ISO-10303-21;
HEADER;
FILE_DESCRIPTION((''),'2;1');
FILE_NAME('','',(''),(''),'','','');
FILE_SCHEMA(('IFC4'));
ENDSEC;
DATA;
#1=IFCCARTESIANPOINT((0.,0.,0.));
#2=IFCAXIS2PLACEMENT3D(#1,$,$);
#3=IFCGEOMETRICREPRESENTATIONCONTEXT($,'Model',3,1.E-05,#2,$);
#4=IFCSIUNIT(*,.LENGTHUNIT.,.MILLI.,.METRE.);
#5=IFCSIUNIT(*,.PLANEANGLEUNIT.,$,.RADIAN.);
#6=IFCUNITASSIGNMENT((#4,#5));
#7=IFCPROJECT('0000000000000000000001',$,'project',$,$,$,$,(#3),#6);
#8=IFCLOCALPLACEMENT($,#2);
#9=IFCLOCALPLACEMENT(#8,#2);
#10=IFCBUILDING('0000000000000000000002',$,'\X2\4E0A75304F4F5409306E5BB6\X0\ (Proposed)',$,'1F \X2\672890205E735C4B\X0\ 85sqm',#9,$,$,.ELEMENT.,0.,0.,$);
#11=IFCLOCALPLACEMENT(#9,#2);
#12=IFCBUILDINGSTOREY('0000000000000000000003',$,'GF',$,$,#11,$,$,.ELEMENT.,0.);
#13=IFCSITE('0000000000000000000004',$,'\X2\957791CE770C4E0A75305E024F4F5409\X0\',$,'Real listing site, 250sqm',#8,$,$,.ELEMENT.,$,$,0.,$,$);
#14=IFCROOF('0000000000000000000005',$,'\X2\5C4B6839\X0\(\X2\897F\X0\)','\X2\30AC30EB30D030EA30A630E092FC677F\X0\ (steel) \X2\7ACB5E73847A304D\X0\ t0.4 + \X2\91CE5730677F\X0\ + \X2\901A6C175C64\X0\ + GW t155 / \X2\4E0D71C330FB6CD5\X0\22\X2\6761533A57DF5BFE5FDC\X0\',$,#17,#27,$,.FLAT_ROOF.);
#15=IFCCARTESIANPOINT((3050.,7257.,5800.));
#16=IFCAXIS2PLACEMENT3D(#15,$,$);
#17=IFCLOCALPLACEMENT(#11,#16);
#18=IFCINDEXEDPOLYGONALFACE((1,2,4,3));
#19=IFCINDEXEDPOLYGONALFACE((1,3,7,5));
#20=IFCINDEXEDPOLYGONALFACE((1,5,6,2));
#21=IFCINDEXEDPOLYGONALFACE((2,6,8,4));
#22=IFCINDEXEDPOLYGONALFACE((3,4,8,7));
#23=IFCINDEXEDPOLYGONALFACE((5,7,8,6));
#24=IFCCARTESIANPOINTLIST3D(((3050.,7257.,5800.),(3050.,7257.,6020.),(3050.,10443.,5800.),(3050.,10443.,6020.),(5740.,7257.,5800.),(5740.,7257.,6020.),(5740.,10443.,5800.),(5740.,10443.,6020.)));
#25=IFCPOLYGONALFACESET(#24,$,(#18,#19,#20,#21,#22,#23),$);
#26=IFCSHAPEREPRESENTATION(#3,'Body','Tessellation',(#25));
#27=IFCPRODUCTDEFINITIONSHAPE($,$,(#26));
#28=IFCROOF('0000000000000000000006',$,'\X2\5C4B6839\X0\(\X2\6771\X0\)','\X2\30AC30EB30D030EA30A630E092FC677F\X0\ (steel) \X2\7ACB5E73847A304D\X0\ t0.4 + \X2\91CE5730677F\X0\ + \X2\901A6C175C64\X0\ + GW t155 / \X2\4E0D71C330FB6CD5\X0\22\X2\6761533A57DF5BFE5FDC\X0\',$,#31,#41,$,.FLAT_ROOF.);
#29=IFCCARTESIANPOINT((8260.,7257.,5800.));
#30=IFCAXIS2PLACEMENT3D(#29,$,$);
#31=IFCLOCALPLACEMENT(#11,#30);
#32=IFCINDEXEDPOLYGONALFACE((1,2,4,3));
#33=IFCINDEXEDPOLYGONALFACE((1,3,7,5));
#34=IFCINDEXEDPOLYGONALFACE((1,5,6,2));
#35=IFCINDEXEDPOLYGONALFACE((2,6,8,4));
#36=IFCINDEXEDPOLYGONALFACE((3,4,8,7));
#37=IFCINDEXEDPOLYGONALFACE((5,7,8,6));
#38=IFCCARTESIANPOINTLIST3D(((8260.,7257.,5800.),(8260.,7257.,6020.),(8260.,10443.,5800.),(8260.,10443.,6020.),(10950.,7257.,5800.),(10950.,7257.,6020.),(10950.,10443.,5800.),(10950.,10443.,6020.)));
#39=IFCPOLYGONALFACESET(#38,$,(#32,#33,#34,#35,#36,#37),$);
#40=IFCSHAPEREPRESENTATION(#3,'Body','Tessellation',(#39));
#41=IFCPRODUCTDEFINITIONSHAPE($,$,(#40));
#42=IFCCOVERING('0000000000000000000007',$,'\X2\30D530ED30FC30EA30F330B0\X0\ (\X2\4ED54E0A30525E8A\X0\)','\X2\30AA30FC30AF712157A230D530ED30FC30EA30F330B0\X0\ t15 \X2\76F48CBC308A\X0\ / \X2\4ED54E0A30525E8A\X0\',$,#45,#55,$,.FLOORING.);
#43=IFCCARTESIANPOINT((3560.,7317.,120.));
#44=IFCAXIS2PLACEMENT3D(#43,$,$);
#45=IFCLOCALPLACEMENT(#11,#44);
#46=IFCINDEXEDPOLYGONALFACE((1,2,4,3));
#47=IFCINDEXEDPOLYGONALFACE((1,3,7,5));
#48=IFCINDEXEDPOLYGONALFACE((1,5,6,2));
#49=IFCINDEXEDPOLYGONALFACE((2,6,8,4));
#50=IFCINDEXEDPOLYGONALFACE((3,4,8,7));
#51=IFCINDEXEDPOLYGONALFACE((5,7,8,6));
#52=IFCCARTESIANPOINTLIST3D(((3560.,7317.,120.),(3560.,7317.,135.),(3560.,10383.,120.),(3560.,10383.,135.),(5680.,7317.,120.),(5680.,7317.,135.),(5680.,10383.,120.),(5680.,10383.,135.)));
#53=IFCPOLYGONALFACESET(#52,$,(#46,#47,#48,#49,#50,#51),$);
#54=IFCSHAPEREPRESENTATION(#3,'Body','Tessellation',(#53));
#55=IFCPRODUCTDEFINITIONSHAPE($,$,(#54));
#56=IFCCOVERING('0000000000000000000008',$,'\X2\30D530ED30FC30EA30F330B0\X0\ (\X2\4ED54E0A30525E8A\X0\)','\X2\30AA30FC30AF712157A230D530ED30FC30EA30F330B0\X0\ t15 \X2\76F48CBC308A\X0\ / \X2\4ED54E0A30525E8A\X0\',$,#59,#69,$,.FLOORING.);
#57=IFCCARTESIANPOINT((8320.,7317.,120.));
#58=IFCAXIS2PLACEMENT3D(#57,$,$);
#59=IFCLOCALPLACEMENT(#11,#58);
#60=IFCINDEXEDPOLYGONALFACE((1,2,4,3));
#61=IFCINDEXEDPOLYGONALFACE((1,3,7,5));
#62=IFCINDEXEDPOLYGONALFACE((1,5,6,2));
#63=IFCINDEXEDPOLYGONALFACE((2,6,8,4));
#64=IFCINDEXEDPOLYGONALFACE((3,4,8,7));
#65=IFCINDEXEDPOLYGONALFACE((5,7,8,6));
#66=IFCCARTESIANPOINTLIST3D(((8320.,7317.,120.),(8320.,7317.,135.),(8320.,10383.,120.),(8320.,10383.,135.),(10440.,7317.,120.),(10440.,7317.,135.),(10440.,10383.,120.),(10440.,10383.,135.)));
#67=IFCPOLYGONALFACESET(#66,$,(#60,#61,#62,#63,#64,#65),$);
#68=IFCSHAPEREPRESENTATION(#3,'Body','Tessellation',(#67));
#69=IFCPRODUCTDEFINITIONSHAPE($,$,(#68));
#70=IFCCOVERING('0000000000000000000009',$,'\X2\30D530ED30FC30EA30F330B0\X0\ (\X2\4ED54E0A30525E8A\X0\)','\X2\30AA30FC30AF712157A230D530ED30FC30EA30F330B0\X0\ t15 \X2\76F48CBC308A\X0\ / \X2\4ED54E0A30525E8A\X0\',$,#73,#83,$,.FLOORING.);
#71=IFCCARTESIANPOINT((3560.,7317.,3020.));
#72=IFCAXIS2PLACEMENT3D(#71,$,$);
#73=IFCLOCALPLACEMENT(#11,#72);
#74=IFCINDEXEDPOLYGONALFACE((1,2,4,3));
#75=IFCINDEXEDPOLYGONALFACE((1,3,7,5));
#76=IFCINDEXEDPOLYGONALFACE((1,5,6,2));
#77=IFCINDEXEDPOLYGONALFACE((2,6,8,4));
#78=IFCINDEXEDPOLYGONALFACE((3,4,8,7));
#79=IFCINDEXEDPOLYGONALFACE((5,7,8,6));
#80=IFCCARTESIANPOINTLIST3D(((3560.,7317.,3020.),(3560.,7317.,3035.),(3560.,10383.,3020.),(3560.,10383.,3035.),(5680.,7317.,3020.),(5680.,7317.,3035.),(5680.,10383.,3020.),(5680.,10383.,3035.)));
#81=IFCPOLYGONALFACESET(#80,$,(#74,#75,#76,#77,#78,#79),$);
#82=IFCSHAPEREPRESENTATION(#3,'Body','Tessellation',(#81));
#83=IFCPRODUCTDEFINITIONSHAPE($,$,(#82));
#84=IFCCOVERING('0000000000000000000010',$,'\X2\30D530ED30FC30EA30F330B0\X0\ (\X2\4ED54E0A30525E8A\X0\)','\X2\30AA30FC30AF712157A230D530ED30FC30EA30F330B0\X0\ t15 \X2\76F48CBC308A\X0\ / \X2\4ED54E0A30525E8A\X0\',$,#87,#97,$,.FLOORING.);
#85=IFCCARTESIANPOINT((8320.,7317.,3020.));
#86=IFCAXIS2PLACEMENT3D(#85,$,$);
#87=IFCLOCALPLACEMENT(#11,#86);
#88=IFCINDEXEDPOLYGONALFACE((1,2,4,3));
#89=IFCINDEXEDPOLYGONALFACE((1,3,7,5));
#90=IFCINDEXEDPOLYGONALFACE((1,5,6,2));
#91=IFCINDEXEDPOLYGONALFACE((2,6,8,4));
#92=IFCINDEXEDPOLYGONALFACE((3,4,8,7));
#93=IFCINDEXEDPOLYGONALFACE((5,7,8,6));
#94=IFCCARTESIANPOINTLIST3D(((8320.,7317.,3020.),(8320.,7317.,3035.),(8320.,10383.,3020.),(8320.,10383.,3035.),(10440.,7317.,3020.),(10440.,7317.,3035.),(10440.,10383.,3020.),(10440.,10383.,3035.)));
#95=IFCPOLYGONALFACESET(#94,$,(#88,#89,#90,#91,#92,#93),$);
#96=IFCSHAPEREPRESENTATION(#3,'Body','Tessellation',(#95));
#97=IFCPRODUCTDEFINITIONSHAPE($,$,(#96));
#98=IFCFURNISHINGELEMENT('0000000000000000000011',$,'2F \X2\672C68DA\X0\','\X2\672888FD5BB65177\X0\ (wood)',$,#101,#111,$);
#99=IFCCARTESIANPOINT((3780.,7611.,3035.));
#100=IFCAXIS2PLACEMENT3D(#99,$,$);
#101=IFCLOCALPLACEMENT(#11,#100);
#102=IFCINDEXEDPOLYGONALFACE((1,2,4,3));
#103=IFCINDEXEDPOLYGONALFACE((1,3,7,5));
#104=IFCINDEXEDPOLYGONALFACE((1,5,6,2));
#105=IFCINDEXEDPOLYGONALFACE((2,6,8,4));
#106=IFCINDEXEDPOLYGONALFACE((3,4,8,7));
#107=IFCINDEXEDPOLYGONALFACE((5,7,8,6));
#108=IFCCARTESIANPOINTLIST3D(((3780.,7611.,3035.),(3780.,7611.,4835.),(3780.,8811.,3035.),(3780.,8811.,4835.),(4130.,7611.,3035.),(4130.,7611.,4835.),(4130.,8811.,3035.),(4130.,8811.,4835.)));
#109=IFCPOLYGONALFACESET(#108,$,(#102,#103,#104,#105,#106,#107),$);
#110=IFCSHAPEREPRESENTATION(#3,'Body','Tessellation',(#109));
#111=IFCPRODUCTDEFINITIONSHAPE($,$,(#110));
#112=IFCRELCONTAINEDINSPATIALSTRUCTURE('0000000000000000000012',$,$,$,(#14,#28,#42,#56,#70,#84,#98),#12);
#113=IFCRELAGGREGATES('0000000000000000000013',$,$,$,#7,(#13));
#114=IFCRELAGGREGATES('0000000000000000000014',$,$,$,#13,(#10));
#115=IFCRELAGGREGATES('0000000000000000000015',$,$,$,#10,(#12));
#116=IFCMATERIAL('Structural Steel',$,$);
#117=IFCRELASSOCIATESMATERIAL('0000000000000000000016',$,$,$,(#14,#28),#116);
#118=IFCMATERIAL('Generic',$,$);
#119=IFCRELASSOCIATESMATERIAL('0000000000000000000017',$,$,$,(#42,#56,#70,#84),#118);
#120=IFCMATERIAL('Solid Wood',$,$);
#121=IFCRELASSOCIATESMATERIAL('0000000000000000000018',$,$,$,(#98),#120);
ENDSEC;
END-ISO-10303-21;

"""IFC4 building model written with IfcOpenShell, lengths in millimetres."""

from ifc_helpers import new_model, si_unit, frame, frame_2d, origin, place, context, project, spatial, rectangle, extrude, material, element, save


model = new_model("IFC4")

# Units and contexts
model_context = context("Model", 3, precision=1e-05, world=origin())
ifc_project = project(units=[si_unit("LENGTHUNIT", "METRE", prefix="MILLI"), si_unit("PLANEANGLEUNIT", "RADIAN")], contexts=[model_context])

# Site, building, storey
site_placement = place(None, origin())
site = spatial("IfcSite", under=ifc_project, at=site_placement, Name="長野県上田市住吉", ObjectType="Real listing site, 250sqm", CompositionType="ELEMENT", RefElevation=0.0)
building_placement = place(site_placement, origin())
building = spatial("IfcBuilding", under=site, at=building_placement, Name="上田住吉の家 (Proposed)", ObjectType="1F 木造平屋 85sqm", CompositionType="ELEMENT", ElevationOfRefHeight=0.0, ElevationOfTerrain=0.0)
storey_placement = place(building_placement, origin())
storey = spatial("IfcBuildingStorey", under=building, at=storey_placement, Name="GF", CompositionType="ELEMENT", Elevation=0.0)

# Shared definitions
ifc_material_1 = material(Name="Solid Wood")

# Shared definitions
ifc_material_2 = material(Name="Generic")

# Roofs
ifc_material_3 = material(Name="Structural Steel")
roof_1_placement = place(storey_placement, frame((3050.0, 7257.0, 5800.0)))
element("IfcRoof", 1, at=roof_1_placement, inside=storey, material=ifc_material_3, Name="屋根(西)", Description="ガルバリウム鋼板 (steel) 立平葺き t0.4 + 野地板 + 通気層 + GW t155 / 不燃・法22条区域対応", PredefinedType="FLAT_ROOF", context=model_context, shape_type="SweptSolid", body=[
    extrude(rectangle(XDim=2690.0, YDim=3186.0, at=frame_2d((1345.0, 1593.0))), frame((3050.0, 7257.0, 5800.0)), (0.0, 0.0, 1.0), 220.0),
])
roof_2_placement = place(storey_placement, frame((8260.0, 7257.0, 5800.0)))
element("IfcRoof", 2, at=roof_2_placement, inside=storey, material=ifc_material_3, Name="屋根(東)", Description="ガルバリウム鋼板 (steel) 立平葺き t0.4 + 野地板 + 通気層 + GW t155 / 不燃・法22条区域対応", PredefinedType="FLAT_ROOF", context=model_context, shape_type="SweptSolid", body=[
    extrude(rectangle(XDim=2690.0, YDim=3186.0, at=frame_2d((1345.0, 1593.0))), frame((8260.0, 7257.0, 5800.0)), (0.0, 0.0, 1.0), 220.0),
])

# Coverings
covering_1_placement = place(storey_placement, frame((3560.0, 7317.0, 120.0)))
element("IfcCovering", 3, at=covering_1_placement, inside=storey, material=ifc_material_2, Name="フローリング (仕上げ床)", Description="オーク無垢フローリング t15 直貼り / 仕上げ床", PredefinedType="FLOORING", context=model_context, shape_type="SweptSolid", body=[
    extrude(rectangle(XDim=2120.0, YDim=3066.0, at=frame_2d((1060.0, 1533.0))), frame((3560.0, 7317.0, 120.0)), (0.0, 0.0, 1.0), 15.0),
])
covering_2_placement = place(storey_placement, frame((8320.0, 7317.0, 120.0)))
element("IfcCovering", 4, at=covering_2_placement, inside=storey, material=ifc_material_2, Name="フローリング (仕上げ床)", Description="オーク無垢フローリング t15 直貼り / 仕上げ床", PredefinedType="FLOORING", context=model_context, shape_type="SweptSolid", body=[
    extrude(rectangle(XDim=2120.0, YDim=3066.0, at=frame_2d((1060.0, 1533.0))), frame((8320.0, 7317.0, 120.0)), (0.0, 0.0, 1.0), 15.0),
])
covering_3_placement = place(storey_placement, frame((3560.0, 7317.0, 3020.0)))
element("IfcCovering", 5, at=covering_3_placement, inside=storey, material=ifc_material_2, Name="フローリング (仕上げ床)", Description="オーク無垢フローリング t15 直貼り / 仕上げ床", PredefinedType="FLOORING", context=model_context, shape_type="SweptSolid", body=[
    extrude(rectangle(XDim=2120.0, YDim=3066.0, at=frame_2d((1060.0, 1533.0))), frame((3560.0, 7317.0, 3020.0)), (0.0, 0.0, 1.0), 15.0),
])
covering_4_placement = place(storey_placement, frame((8320.0, 7317.0, 3020.0)))
element("IfcCovering", 6, at=covering_4_placement, inside=storey, material=ifc_material_2, Name="フローリング (仕上げ床)", Description="オーク無垢フローリング t15 直貼り / 仕上げ床", PredefinedType="FLOORING", context=model_context, shape_type="SweptSolid", body=[
    extrude(rectangle(XDim=2120.0, YDim=3066.0, at=frame_2d((1060.0, 1533.0))), frame((8320.0, 7317.0, 3020.0)), (0.0, 0.0, 1.0), 15.0),
])

# Furnishing element
furnishing_placement = place(storey_placement, frame((3780.0, 7611.0, 3035.0)))
element("IfcFurnishingElement", 7, at=furnishing_placement, inside=storey, material=ifc_material_1, Name="2F 本棚", Description="木製家具 (wood)", context=model_context, shape_type="SweptSolid", body=[
    extrude(rectangle(XDim=350.0, YDim=1200.0, at=frame_2d((175.0, 600.0))), frame((3780.0, 7611.0, 3035.0)), (0.0, 0.0, 1.0), 1800.0),
])

save(model, "model.ifc")
